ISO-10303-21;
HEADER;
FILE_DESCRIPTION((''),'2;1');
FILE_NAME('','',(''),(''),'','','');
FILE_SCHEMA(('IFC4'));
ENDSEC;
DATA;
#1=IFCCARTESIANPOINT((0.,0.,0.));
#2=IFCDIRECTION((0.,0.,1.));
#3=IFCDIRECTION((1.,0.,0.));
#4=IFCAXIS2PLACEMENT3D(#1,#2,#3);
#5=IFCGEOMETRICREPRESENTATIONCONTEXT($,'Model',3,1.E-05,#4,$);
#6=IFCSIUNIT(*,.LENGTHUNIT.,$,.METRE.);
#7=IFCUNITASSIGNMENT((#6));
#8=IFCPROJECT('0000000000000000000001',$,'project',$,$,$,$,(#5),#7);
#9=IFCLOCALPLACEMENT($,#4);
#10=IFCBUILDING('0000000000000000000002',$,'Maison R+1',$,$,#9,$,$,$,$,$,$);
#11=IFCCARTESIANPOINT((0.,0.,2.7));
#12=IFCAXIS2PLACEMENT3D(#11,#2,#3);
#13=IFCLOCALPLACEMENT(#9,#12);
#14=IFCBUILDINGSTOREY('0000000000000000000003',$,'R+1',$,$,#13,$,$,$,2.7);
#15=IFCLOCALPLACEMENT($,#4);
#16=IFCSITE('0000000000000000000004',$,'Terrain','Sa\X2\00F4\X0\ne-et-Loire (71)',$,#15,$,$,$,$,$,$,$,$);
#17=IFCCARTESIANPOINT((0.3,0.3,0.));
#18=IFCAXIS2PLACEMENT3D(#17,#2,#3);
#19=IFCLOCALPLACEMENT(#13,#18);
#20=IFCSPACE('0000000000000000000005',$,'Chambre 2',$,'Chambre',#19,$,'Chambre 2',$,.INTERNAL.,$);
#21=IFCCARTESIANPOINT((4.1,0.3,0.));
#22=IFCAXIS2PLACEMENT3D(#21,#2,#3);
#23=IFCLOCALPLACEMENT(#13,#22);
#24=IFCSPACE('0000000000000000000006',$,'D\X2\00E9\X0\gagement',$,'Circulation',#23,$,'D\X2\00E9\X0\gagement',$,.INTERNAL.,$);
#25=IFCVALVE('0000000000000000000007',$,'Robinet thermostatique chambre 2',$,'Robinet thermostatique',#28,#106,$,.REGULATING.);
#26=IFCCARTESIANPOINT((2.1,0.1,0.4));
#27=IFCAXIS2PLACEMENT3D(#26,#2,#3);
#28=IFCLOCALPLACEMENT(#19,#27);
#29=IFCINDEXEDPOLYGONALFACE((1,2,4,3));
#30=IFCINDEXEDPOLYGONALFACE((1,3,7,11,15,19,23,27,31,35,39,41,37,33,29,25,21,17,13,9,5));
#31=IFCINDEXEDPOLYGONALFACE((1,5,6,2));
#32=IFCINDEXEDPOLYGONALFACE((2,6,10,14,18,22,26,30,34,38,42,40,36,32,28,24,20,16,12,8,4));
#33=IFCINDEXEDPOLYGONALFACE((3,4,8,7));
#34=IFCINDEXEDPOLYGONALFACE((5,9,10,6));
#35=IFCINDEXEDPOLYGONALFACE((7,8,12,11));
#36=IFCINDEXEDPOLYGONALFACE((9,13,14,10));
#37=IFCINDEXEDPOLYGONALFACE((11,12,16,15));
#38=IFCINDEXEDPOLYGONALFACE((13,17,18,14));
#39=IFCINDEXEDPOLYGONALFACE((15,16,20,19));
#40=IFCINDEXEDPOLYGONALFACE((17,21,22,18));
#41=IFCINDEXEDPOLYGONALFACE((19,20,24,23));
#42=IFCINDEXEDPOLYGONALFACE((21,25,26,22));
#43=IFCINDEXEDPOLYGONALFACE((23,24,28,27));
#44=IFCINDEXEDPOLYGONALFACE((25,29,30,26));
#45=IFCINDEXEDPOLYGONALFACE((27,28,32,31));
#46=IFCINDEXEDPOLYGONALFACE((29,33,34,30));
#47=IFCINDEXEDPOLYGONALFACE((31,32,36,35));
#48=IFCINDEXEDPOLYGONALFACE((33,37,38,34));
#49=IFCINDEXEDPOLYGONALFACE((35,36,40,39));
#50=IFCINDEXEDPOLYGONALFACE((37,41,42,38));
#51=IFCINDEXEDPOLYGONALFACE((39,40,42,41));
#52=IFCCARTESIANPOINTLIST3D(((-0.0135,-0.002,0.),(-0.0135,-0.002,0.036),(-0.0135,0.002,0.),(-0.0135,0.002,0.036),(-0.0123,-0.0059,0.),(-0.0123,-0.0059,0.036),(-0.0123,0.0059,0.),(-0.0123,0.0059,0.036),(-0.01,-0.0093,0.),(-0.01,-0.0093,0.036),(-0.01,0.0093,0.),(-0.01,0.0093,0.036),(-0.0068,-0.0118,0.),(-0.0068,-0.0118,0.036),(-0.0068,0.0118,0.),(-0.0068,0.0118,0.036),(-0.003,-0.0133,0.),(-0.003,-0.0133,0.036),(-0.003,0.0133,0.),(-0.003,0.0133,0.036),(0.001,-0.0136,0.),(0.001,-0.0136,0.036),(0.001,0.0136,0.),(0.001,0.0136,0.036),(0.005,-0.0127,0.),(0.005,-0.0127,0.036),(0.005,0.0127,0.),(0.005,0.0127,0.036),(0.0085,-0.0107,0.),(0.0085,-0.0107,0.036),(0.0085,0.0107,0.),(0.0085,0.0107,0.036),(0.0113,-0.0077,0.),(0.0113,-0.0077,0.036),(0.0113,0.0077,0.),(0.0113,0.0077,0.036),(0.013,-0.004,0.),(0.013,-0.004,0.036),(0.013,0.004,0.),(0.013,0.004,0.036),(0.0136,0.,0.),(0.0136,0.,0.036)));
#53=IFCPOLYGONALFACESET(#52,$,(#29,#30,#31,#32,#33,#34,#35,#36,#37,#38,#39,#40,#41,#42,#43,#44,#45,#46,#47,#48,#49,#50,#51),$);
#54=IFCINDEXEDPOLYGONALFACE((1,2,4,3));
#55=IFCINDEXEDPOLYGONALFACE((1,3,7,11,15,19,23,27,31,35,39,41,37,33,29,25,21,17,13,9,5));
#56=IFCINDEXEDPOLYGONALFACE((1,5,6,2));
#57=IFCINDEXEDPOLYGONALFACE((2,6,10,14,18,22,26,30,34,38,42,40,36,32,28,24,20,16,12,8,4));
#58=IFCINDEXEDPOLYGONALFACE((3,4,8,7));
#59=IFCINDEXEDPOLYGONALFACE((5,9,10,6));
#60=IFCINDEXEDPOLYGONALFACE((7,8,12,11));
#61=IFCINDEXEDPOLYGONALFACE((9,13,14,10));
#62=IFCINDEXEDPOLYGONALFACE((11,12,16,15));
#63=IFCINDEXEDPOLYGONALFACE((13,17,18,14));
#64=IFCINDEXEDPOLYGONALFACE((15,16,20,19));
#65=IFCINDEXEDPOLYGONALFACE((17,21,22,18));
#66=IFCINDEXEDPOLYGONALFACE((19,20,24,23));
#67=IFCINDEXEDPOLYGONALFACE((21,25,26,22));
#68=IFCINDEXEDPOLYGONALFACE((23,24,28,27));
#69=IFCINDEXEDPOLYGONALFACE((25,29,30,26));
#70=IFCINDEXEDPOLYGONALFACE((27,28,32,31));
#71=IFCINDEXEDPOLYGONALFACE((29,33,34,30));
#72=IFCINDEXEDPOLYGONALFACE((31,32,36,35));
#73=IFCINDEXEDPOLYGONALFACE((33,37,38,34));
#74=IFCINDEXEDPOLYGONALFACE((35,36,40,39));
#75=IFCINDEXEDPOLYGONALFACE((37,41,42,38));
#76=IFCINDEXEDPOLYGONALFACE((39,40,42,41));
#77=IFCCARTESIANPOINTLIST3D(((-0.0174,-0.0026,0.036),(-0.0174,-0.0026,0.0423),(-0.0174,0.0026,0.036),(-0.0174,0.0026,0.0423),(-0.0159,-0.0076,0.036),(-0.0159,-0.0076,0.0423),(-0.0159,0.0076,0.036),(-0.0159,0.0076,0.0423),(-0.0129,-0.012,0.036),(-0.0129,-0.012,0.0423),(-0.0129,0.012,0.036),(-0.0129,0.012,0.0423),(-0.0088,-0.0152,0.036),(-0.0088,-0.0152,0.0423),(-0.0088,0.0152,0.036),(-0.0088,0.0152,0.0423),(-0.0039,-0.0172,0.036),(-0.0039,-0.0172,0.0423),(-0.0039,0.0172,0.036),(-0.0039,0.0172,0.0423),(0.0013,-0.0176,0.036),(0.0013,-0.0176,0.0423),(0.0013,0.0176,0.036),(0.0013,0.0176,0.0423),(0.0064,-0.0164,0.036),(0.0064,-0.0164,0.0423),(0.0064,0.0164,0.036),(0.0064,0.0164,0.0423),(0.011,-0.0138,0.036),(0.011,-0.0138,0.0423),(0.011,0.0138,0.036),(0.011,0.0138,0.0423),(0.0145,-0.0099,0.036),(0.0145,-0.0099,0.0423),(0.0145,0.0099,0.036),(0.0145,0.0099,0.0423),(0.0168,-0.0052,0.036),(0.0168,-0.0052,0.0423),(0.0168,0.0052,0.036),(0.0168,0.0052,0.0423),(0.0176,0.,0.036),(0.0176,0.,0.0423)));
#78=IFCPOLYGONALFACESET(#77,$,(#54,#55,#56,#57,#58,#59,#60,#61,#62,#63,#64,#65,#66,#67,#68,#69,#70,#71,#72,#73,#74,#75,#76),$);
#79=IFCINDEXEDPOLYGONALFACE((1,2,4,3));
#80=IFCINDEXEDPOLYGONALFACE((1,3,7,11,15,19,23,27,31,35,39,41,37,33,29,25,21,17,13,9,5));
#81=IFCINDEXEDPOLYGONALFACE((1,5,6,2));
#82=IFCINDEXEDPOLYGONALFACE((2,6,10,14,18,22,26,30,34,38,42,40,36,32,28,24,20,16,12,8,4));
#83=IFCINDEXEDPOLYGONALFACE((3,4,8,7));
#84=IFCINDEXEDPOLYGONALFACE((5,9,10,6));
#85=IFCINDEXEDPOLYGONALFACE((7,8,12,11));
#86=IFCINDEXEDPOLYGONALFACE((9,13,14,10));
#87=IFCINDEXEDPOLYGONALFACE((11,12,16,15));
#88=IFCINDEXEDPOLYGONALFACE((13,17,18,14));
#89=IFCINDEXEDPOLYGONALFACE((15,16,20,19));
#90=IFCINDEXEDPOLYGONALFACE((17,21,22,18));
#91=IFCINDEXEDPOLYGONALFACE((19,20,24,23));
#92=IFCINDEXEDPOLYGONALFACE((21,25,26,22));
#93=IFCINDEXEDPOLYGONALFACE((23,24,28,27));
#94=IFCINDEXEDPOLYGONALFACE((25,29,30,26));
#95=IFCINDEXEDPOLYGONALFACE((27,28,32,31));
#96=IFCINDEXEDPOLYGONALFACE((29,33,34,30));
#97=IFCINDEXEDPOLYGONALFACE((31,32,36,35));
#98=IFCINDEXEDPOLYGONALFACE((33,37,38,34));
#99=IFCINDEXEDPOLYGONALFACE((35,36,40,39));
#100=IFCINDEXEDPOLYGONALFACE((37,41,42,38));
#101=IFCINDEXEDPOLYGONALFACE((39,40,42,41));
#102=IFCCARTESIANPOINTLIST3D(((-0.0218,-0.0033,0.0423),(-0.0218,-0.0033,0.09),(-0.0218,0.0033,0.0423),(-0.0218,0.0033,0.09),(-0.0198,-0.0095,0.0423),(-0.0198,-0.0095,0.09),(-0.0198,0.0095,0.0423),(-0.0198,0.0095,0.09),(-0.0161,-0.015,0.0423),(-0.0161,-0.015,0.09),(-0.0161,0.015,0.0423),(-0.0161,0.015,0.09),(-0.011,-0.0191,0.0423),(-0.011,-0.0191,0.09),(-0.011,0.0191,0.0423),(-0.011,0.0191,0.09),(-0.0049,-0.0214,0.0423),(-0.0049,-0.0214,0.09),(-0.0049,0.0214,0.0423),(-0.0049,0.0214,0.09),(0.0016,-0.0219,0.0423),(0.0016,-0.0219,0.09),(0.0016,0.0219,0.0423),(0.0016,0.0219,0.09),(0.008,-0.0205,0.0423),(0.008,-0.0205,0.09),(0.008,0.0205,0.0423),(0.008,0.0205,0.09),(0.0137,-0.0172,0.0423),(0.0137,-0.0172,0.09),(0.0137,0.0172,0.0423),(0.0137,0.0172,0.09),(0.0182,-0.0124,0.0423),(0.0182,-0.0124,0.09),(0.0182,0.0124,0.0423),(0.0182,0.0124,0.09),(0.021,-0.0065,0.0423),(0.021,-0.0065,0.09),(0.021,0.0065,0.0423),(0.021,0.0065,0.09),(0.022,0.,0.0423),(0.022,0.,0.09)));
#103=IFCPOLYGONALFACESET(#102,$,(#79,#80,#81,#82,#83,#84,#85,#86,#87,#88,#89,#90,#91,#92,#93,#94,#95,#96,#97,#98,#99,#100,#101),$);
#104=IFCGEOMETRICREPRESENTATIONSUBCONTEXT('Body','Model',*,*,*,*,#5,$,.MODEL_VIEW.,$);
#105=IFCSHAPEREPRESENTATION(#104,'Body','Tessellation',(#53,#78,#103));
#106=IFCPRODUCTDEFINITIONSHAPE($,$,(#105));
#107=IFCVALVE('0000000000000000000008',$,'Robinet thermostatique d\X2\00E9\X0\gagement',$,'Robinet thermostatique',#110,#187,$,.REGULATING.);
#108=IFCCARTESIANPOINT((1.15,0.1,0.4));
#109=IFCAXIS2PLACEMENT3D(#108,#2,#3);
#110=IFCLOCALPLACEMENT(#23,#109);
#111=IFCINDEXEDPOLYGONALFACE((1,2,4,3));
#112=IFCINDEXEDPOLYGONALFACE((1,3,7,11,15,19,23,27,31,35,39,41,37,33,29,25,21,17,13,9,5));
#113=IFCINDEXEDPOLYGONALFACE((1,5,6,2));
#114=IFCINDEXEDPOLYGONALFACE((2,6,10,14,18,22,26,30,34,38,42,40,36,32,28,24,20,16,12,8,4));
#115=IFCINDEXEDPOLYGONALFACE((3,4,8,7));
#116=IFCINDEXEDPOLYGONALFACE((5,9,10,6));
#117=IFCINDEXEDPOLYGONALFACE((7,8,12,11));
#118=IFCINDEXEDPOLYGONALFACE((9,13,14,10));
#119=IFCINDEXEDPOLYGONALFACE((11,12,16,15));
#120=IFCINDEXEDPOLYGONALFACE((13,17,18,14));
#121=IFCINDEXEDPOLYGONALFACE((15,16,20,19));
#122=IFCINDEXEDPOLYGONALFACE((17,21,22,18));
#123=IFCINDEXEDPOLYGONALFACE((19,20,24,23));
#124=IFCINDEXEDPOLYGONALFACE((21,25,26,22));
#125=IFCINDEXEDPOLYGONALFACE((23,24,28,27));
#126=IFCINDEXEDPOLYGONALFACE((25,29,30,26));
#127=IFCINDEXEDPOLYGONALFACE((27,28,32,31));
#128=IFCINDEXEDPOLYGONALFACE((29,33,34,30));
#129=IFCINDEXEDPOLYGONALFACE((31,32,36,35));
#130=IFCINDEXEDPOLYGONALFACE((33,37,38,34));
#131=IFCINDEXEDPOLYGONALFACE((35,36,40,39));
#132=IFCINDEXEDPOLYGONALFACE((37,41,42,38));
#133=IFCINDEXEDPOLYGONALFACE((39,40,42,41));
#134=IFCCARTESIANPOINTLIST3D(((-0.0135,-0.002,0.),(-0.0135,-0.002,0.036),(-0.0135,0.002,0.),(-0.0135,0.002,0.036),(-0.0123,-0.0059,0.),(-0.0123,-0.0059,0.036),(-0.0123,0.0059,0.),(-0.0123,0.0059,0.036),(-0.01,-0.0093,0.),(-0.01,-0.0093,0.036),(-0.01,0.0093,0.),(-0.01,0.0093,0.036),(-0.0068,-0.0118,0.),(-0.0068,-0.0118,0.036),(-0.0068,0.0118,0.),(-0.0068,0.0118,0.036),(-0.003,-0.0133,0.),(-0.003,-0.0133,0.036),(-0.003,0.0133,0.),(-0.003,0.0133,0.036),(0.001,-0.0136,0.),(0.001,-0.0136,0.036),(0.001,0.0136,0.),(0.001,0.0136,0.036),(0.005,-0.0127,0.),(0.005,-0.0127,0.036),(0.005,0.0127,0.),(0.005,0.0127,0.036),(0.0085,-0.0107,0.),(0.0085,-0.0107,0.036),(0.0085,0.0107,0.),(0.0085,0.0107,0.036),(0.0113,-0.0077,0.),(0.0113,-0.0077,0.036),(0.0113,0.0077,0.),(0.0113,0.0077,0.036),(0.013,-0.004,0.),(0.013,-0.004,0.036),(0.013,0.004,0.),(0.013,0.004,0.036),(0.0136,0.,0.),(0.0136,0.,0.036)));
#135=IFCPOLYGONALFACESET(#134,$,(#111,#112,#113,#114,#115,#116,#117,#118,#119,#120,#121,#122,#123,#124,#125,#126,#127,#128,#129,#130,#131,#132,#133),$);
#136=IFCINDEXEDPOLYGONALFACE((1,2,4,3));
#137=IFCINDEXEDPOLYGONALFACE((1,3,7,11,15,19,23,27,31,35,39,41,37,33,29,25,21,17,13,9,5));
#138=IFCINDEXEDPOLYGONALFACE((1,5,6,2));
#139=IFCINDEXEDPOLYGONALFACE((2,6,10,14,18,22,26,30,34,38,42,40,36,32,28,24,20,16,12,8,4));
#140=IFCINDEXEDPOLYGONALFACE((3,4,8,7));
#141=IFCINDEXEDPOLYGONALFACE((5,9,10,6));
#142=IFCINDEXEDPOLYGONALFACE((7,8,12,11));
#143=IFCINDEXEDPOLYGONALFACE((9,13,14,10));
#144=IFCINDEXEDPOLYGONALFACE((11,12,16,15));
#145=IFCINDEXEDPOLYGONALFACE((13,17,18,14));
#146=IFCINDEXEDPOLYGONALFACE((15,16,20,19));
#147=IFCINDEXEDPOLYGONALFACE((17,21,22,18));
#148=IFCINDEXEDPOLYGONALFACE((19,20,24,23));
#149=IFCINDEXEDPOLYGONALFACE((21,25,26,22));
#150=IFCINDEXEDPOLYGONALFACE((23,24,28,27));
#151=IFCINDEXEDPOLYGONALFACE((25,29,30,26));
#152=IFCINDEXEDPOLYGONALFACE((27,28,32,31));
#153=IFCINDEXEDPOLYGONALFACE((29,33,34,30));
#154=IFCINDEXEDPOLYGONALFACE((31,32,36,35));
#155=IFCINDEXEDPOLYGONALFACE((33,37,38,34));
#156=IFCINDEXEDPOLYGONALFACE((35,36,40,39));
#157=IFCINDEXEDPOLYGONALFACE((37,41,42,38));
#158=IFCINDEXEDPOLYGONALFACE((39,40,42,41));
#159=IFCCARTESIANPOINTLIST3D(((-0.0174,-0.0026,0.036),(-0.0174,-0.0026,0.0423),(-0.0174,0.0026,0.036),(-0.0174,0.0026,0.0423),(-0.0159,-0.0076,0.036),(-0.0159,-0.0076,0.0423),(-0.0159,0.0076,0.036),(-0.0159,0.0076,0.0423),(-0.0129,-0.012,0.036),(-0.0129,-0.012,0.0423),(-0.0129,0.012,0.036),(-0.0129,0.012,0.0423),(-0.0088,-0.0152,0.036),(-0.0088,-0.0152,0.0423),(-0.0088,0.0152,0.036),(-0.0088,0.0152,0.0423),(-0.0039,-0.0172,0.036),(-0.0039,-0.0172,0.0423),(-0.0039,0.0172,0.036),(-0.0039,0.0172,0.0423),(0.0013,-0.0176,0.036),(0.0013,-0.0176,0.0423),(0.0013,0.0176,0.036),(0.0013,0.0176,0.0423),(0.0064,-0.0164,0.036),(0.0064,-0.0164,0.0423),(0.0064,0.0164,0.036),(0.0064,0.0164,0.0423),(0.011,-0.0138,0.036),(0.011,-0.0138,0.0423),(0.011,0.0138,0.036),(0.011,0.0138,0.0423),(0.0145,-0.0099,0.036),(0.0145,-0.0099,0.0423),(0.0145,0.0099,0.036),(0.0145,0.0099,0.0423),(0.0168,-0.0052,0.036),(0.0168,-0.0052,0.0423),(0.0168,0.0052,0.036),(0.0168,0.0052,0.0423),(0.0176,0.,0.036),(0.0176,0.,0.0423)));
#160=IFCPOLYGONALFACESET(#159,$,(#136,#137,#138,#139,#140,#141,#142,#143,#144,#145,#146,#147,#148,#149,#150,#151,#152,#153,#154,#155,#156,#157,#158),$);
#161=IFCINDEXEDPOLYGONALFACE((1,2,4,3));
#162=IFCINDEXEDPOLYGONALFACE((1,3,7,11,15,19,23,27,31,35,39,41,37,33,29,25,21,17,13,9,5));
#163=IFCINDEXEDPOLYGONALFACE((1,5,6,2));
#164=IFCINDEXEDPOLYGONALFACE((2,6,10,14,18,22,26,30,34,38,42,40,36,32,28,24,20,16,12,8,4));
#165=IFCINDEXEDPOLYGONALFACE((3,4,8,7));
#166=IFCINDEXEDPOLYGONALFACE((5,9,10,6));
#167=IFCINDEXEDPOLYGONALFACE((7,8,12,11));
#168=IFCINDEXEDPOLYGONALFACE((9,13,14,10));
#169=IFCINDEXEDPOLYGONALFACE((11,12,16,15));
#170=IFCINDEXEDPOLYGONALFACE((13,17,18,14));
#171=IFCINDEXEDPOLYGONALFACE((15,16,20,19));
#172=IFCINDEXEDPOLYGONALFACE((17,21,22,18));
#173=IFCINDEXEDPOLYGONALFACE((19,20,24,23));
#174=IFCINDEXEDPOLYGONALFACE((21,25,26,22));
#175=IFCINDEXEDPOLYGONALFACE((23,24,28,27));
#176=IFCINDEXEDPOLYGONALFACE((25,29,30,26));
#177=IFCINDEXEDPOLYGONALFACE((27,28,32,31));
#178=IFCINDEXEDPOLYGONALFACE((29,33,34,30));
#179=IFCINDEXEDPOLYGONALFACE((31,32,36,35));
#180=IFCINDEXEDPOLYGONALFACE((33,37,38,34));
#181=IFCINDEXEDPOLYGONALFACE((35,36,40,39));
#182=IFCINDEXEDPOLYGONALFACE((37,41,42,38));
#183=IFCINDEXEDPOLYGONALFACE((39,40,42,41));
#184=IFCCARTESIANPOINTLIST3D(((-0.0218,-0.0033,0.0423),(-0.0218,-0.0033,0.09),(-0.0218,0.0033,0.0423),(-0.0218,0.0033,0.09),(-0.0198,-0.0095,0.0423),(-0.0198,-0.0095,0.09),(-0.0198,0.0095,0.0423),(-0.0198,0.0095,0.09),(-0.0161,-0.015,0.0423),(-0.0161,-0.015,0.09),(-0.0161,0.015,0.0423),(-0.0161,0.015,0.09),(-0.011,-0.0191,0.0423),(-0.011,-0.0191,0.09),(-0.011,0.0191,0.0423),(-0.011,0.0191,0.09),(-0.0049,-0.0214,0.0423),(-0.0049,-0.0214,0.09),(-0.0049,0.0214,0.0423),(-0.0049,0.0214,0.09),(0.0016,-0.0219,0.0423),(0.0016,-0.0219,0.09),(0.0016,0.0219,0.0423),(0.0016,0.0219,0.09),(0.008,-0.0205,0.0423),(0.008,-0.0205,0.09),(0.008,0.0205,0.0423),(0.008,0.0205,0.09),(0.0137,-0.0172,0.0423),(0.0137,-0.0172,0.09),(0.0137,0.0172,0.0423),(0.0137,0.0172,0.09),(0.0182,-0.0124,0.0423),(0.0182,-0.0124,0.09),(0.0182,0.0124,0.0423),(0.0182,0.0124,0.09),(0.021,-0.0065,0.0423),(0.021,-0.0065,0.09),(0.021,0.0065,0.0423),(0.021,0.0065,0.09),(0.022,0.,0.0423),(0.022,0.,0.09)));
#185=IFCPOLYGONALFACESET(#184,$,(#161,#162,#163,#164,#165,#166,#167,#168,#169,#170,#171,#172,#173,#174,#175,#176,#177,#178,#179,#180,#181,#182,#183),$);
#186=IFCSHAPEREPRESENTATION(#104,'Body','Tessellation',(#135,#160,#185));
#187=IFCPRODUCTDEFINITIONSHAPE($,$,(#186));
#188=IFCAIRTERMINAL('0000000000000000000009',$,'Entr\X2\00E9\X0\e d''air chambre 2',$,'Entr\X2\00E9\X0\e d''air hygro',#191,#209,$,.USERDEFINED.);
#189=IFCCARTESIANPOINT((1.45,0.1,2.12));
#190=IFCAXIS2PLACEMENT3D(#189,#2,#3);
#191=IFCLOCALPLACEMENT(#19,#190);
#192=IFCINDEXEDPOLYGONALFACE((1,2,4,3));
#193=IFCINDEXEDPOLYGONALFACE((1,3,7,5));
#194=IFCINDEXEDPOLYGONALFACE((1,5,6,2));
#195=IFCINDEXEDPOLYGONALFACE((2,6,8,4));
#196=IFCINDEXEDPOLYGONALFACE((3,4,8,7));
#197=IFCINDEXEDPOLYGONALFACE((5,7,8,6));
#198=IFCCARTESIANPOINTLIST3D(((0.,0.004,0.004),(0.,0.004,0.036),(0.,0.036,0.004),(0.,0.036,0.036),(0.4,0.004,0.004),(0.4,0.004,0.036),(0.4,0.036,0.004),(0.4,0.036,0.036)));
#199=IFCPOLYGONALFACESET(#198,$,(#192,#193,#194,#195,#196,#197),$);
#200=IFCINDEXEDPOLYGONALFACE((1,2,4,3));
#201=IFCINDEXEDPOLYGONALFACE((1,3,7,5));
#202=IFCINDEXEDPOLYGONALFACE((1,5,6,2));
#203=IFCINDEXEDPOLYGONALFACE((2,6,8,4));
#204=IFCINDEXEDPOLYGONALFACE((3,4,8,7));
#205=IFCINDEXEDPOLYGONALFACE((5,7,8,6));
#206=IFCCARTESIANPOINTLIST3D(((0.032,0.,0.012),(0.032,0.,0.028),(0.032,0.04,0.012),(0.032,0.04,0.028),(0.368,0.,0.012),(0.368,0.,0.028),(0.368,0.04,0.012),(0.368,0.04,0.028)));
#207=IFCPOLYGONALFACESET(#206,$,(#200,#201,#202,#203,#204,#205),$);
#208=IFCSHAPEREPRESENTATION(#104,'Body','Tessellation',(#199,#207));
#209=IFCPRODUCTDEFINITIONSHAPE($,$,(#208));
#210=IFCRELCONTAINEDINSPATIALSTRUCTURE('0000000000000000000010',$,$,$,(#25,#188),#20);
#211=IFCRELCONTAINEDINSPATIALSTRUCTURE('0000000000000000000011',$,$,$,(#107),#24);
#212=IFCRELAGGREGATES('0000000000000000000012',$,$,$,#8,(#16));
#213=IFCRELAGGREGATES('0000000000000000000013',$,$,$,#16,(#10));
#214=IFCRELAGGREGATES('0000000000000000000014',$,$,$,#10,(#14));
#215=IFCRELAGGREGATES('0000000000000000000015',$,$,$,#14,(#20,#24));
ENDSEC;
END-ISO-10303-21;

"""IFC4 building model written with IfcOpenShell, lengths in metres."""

from ifc_helpers import new_model, si_unit, frame, frame_2d, origin_with_axes, place, context, subcontext, project, spatial, rectangle, circle, extrude, element, save


model = new_model("IFC4")

# Units and contexts
model_context = context("Model", 3, precision=1e-05, world=origin_with_axes())
body_context = subcontext(model_context, "Body", "Model", "MODEL_VIEW")
ifc_project = project(units=[si_unit("LENGTHUNIT", "METRE")], contexts=[model_context])

# Site, building, storey
site_placement = place(None, origin_with_axes())
site = spatial("IfcSite", under=ifc_project, at=site_placement, Name="Terrain", Description="Saône-et-Loire (71)")
building_placement = place(None, origin_with_axes())
building = spatial("IfcBuilding", under=site, at=building_placement, Name="Maison R+1")
storey_placement = place(building_placement, frame((0.0, 0.0, 2.7), z_axis=(0.0, 0.0, 1.0), x_axis=(1.0, 0.0, 0.0)))
storey = spatial("IfcBuildingStorey", under=building, at=storey_placement, Name="R+1", Elevation=2.7)

# Shared definitions
space_1_placement = place(storey_placement, frame((0.3, 0.3, 0.0), z_axis=(0.0, 0.0, 1.0), x_axis=(1.0, 0.0, 0.0)))
space_1 = spatial("IfcSpace", under=storey, at=space_1_placement, Name="Chambre 2", ObjectType="Chambre", LongName="Chambre 2", PredefinedType="INTERNAL")

# Valve
valve_1_placement = place(space_1_placement, frame((2.1, 0.1, 0.4), z_axis=(0.0, 0.0, 1.0), x_axis=(1.0, 0.0, 0.0)))
element("IfcValve", 1, at=valve_1_placement, inside=space_1, Name="Robinet thermostatique chambre 2", ObjectType="Robinet thermostatique", PredefinedType="REGULATING", context=body_context, shape_type="SweptSolid", body=[
    extrude(circle(Radius=0.0136), origin_with_axes(), (0.0, 0.0, 1.0), 0.036),
    extrude(circle(Radius=0.0176), frame((0.0, 0.0, 0.036), z_axis=(0.0, 0.0, 1.0), x_axis=(1.0, 0.0, 0.0)), (0.0, 0.0, 1.0), 0.0063),
    extrude(circle(Radius=0.022), frame((0.0, 0.0, 0.0423), z_axis=(0.0, 0.0, 1.0), x_axis=(1.0, 0.0, 0.0)), (0.0, 0.0, 1.0), 0.0477),
])

# Shared definitions
space_2_placement = place(storey_placement, frame((4.1, 0.3, 0.0), z_axis=(0.0, 0.0, 1.0), x_axis=(1.0, 0.0, 0.0)))
space_2 = spatial("IfcSpace", under=storey, at=space_2_placement, Name="Dégagement", ObjectType="Circulation", LongName="Dégagement", PredefinedType="INTERNAL")

# Valve
valve_2_placement = place(space_2_placement, frame((1.15, 0.1, 0.4), z_axis=(0.0, 0.0, 1.0), x_axis=(1.0, 0.0, 0.0)))
element("IfcValve", 2, at=valve_2_placement, inside=space_2, Name="Robinet thermostatique dégagement", ObjectType="Robinet thermostatique", PredefinedType="REGULATING", context=body_context, shape_type="SweptSolid", body=[
    extrude(circle(Radius=0.0136), origin_with_axes(), (0.0, 0.0, 1.0), 0.036),
    extrude(circle(Radius=0.0176), frame((0.0, 0.0, 0.036), z_axis=(0.0, 0.0, 1.0), x_axis=(1.0, 0.0, 0.0)), (0.0, 0.0, 1.0), 0.0063),
    extrude(circle(Radius=0.022), frame((0.0, 0.0, 0.0423), z_axis=(0.0, 0.0, 1.0), x_axis=(1.0, 0.0, 0.0)), (0.0, 0.0, 1.0), 0.0477),
])

# Air terminal
air_terminal_placement = place(space_1_placement, frame((1.45, 0.1, 2.12), z_axis=(0.0, 0.0, 1.0), x_axis=(1.0, 0.0, 0.0)))
element("IfcAirTerminal", 3, at=air_terminal_placement, inside=space_1, Name="Entrée d'air chambre 2", ObjectType="Entrée d'air hygro", PredefinedType="USERDEFINED", context=body_context, shape_type="SweptSolid", body=[
    extrude(rectangle(XDim=0.4, YDim=0.032, at=frame_2d((0.2, 0.016))), frame((0.0, 0.004, 0.004), z_axis=(0.0, 0.0, 1.0), x_axis=(1.0, 0.0, 0.0)), (0.0, 0.0, 1.0), 0.032),
    extrude(rectangle(XDim=0.336, YDim=0.04, at=frame_2d((0.168, 0.02))), frame((0.032, 0.0, 0.012), z_axis=(0.0, 0.0, 1.0), x_axis=(1.0, 0.0, 0.0)), (0.0, 0.0, 1.0), 0.016),
])

save(model, "model.ifc")
